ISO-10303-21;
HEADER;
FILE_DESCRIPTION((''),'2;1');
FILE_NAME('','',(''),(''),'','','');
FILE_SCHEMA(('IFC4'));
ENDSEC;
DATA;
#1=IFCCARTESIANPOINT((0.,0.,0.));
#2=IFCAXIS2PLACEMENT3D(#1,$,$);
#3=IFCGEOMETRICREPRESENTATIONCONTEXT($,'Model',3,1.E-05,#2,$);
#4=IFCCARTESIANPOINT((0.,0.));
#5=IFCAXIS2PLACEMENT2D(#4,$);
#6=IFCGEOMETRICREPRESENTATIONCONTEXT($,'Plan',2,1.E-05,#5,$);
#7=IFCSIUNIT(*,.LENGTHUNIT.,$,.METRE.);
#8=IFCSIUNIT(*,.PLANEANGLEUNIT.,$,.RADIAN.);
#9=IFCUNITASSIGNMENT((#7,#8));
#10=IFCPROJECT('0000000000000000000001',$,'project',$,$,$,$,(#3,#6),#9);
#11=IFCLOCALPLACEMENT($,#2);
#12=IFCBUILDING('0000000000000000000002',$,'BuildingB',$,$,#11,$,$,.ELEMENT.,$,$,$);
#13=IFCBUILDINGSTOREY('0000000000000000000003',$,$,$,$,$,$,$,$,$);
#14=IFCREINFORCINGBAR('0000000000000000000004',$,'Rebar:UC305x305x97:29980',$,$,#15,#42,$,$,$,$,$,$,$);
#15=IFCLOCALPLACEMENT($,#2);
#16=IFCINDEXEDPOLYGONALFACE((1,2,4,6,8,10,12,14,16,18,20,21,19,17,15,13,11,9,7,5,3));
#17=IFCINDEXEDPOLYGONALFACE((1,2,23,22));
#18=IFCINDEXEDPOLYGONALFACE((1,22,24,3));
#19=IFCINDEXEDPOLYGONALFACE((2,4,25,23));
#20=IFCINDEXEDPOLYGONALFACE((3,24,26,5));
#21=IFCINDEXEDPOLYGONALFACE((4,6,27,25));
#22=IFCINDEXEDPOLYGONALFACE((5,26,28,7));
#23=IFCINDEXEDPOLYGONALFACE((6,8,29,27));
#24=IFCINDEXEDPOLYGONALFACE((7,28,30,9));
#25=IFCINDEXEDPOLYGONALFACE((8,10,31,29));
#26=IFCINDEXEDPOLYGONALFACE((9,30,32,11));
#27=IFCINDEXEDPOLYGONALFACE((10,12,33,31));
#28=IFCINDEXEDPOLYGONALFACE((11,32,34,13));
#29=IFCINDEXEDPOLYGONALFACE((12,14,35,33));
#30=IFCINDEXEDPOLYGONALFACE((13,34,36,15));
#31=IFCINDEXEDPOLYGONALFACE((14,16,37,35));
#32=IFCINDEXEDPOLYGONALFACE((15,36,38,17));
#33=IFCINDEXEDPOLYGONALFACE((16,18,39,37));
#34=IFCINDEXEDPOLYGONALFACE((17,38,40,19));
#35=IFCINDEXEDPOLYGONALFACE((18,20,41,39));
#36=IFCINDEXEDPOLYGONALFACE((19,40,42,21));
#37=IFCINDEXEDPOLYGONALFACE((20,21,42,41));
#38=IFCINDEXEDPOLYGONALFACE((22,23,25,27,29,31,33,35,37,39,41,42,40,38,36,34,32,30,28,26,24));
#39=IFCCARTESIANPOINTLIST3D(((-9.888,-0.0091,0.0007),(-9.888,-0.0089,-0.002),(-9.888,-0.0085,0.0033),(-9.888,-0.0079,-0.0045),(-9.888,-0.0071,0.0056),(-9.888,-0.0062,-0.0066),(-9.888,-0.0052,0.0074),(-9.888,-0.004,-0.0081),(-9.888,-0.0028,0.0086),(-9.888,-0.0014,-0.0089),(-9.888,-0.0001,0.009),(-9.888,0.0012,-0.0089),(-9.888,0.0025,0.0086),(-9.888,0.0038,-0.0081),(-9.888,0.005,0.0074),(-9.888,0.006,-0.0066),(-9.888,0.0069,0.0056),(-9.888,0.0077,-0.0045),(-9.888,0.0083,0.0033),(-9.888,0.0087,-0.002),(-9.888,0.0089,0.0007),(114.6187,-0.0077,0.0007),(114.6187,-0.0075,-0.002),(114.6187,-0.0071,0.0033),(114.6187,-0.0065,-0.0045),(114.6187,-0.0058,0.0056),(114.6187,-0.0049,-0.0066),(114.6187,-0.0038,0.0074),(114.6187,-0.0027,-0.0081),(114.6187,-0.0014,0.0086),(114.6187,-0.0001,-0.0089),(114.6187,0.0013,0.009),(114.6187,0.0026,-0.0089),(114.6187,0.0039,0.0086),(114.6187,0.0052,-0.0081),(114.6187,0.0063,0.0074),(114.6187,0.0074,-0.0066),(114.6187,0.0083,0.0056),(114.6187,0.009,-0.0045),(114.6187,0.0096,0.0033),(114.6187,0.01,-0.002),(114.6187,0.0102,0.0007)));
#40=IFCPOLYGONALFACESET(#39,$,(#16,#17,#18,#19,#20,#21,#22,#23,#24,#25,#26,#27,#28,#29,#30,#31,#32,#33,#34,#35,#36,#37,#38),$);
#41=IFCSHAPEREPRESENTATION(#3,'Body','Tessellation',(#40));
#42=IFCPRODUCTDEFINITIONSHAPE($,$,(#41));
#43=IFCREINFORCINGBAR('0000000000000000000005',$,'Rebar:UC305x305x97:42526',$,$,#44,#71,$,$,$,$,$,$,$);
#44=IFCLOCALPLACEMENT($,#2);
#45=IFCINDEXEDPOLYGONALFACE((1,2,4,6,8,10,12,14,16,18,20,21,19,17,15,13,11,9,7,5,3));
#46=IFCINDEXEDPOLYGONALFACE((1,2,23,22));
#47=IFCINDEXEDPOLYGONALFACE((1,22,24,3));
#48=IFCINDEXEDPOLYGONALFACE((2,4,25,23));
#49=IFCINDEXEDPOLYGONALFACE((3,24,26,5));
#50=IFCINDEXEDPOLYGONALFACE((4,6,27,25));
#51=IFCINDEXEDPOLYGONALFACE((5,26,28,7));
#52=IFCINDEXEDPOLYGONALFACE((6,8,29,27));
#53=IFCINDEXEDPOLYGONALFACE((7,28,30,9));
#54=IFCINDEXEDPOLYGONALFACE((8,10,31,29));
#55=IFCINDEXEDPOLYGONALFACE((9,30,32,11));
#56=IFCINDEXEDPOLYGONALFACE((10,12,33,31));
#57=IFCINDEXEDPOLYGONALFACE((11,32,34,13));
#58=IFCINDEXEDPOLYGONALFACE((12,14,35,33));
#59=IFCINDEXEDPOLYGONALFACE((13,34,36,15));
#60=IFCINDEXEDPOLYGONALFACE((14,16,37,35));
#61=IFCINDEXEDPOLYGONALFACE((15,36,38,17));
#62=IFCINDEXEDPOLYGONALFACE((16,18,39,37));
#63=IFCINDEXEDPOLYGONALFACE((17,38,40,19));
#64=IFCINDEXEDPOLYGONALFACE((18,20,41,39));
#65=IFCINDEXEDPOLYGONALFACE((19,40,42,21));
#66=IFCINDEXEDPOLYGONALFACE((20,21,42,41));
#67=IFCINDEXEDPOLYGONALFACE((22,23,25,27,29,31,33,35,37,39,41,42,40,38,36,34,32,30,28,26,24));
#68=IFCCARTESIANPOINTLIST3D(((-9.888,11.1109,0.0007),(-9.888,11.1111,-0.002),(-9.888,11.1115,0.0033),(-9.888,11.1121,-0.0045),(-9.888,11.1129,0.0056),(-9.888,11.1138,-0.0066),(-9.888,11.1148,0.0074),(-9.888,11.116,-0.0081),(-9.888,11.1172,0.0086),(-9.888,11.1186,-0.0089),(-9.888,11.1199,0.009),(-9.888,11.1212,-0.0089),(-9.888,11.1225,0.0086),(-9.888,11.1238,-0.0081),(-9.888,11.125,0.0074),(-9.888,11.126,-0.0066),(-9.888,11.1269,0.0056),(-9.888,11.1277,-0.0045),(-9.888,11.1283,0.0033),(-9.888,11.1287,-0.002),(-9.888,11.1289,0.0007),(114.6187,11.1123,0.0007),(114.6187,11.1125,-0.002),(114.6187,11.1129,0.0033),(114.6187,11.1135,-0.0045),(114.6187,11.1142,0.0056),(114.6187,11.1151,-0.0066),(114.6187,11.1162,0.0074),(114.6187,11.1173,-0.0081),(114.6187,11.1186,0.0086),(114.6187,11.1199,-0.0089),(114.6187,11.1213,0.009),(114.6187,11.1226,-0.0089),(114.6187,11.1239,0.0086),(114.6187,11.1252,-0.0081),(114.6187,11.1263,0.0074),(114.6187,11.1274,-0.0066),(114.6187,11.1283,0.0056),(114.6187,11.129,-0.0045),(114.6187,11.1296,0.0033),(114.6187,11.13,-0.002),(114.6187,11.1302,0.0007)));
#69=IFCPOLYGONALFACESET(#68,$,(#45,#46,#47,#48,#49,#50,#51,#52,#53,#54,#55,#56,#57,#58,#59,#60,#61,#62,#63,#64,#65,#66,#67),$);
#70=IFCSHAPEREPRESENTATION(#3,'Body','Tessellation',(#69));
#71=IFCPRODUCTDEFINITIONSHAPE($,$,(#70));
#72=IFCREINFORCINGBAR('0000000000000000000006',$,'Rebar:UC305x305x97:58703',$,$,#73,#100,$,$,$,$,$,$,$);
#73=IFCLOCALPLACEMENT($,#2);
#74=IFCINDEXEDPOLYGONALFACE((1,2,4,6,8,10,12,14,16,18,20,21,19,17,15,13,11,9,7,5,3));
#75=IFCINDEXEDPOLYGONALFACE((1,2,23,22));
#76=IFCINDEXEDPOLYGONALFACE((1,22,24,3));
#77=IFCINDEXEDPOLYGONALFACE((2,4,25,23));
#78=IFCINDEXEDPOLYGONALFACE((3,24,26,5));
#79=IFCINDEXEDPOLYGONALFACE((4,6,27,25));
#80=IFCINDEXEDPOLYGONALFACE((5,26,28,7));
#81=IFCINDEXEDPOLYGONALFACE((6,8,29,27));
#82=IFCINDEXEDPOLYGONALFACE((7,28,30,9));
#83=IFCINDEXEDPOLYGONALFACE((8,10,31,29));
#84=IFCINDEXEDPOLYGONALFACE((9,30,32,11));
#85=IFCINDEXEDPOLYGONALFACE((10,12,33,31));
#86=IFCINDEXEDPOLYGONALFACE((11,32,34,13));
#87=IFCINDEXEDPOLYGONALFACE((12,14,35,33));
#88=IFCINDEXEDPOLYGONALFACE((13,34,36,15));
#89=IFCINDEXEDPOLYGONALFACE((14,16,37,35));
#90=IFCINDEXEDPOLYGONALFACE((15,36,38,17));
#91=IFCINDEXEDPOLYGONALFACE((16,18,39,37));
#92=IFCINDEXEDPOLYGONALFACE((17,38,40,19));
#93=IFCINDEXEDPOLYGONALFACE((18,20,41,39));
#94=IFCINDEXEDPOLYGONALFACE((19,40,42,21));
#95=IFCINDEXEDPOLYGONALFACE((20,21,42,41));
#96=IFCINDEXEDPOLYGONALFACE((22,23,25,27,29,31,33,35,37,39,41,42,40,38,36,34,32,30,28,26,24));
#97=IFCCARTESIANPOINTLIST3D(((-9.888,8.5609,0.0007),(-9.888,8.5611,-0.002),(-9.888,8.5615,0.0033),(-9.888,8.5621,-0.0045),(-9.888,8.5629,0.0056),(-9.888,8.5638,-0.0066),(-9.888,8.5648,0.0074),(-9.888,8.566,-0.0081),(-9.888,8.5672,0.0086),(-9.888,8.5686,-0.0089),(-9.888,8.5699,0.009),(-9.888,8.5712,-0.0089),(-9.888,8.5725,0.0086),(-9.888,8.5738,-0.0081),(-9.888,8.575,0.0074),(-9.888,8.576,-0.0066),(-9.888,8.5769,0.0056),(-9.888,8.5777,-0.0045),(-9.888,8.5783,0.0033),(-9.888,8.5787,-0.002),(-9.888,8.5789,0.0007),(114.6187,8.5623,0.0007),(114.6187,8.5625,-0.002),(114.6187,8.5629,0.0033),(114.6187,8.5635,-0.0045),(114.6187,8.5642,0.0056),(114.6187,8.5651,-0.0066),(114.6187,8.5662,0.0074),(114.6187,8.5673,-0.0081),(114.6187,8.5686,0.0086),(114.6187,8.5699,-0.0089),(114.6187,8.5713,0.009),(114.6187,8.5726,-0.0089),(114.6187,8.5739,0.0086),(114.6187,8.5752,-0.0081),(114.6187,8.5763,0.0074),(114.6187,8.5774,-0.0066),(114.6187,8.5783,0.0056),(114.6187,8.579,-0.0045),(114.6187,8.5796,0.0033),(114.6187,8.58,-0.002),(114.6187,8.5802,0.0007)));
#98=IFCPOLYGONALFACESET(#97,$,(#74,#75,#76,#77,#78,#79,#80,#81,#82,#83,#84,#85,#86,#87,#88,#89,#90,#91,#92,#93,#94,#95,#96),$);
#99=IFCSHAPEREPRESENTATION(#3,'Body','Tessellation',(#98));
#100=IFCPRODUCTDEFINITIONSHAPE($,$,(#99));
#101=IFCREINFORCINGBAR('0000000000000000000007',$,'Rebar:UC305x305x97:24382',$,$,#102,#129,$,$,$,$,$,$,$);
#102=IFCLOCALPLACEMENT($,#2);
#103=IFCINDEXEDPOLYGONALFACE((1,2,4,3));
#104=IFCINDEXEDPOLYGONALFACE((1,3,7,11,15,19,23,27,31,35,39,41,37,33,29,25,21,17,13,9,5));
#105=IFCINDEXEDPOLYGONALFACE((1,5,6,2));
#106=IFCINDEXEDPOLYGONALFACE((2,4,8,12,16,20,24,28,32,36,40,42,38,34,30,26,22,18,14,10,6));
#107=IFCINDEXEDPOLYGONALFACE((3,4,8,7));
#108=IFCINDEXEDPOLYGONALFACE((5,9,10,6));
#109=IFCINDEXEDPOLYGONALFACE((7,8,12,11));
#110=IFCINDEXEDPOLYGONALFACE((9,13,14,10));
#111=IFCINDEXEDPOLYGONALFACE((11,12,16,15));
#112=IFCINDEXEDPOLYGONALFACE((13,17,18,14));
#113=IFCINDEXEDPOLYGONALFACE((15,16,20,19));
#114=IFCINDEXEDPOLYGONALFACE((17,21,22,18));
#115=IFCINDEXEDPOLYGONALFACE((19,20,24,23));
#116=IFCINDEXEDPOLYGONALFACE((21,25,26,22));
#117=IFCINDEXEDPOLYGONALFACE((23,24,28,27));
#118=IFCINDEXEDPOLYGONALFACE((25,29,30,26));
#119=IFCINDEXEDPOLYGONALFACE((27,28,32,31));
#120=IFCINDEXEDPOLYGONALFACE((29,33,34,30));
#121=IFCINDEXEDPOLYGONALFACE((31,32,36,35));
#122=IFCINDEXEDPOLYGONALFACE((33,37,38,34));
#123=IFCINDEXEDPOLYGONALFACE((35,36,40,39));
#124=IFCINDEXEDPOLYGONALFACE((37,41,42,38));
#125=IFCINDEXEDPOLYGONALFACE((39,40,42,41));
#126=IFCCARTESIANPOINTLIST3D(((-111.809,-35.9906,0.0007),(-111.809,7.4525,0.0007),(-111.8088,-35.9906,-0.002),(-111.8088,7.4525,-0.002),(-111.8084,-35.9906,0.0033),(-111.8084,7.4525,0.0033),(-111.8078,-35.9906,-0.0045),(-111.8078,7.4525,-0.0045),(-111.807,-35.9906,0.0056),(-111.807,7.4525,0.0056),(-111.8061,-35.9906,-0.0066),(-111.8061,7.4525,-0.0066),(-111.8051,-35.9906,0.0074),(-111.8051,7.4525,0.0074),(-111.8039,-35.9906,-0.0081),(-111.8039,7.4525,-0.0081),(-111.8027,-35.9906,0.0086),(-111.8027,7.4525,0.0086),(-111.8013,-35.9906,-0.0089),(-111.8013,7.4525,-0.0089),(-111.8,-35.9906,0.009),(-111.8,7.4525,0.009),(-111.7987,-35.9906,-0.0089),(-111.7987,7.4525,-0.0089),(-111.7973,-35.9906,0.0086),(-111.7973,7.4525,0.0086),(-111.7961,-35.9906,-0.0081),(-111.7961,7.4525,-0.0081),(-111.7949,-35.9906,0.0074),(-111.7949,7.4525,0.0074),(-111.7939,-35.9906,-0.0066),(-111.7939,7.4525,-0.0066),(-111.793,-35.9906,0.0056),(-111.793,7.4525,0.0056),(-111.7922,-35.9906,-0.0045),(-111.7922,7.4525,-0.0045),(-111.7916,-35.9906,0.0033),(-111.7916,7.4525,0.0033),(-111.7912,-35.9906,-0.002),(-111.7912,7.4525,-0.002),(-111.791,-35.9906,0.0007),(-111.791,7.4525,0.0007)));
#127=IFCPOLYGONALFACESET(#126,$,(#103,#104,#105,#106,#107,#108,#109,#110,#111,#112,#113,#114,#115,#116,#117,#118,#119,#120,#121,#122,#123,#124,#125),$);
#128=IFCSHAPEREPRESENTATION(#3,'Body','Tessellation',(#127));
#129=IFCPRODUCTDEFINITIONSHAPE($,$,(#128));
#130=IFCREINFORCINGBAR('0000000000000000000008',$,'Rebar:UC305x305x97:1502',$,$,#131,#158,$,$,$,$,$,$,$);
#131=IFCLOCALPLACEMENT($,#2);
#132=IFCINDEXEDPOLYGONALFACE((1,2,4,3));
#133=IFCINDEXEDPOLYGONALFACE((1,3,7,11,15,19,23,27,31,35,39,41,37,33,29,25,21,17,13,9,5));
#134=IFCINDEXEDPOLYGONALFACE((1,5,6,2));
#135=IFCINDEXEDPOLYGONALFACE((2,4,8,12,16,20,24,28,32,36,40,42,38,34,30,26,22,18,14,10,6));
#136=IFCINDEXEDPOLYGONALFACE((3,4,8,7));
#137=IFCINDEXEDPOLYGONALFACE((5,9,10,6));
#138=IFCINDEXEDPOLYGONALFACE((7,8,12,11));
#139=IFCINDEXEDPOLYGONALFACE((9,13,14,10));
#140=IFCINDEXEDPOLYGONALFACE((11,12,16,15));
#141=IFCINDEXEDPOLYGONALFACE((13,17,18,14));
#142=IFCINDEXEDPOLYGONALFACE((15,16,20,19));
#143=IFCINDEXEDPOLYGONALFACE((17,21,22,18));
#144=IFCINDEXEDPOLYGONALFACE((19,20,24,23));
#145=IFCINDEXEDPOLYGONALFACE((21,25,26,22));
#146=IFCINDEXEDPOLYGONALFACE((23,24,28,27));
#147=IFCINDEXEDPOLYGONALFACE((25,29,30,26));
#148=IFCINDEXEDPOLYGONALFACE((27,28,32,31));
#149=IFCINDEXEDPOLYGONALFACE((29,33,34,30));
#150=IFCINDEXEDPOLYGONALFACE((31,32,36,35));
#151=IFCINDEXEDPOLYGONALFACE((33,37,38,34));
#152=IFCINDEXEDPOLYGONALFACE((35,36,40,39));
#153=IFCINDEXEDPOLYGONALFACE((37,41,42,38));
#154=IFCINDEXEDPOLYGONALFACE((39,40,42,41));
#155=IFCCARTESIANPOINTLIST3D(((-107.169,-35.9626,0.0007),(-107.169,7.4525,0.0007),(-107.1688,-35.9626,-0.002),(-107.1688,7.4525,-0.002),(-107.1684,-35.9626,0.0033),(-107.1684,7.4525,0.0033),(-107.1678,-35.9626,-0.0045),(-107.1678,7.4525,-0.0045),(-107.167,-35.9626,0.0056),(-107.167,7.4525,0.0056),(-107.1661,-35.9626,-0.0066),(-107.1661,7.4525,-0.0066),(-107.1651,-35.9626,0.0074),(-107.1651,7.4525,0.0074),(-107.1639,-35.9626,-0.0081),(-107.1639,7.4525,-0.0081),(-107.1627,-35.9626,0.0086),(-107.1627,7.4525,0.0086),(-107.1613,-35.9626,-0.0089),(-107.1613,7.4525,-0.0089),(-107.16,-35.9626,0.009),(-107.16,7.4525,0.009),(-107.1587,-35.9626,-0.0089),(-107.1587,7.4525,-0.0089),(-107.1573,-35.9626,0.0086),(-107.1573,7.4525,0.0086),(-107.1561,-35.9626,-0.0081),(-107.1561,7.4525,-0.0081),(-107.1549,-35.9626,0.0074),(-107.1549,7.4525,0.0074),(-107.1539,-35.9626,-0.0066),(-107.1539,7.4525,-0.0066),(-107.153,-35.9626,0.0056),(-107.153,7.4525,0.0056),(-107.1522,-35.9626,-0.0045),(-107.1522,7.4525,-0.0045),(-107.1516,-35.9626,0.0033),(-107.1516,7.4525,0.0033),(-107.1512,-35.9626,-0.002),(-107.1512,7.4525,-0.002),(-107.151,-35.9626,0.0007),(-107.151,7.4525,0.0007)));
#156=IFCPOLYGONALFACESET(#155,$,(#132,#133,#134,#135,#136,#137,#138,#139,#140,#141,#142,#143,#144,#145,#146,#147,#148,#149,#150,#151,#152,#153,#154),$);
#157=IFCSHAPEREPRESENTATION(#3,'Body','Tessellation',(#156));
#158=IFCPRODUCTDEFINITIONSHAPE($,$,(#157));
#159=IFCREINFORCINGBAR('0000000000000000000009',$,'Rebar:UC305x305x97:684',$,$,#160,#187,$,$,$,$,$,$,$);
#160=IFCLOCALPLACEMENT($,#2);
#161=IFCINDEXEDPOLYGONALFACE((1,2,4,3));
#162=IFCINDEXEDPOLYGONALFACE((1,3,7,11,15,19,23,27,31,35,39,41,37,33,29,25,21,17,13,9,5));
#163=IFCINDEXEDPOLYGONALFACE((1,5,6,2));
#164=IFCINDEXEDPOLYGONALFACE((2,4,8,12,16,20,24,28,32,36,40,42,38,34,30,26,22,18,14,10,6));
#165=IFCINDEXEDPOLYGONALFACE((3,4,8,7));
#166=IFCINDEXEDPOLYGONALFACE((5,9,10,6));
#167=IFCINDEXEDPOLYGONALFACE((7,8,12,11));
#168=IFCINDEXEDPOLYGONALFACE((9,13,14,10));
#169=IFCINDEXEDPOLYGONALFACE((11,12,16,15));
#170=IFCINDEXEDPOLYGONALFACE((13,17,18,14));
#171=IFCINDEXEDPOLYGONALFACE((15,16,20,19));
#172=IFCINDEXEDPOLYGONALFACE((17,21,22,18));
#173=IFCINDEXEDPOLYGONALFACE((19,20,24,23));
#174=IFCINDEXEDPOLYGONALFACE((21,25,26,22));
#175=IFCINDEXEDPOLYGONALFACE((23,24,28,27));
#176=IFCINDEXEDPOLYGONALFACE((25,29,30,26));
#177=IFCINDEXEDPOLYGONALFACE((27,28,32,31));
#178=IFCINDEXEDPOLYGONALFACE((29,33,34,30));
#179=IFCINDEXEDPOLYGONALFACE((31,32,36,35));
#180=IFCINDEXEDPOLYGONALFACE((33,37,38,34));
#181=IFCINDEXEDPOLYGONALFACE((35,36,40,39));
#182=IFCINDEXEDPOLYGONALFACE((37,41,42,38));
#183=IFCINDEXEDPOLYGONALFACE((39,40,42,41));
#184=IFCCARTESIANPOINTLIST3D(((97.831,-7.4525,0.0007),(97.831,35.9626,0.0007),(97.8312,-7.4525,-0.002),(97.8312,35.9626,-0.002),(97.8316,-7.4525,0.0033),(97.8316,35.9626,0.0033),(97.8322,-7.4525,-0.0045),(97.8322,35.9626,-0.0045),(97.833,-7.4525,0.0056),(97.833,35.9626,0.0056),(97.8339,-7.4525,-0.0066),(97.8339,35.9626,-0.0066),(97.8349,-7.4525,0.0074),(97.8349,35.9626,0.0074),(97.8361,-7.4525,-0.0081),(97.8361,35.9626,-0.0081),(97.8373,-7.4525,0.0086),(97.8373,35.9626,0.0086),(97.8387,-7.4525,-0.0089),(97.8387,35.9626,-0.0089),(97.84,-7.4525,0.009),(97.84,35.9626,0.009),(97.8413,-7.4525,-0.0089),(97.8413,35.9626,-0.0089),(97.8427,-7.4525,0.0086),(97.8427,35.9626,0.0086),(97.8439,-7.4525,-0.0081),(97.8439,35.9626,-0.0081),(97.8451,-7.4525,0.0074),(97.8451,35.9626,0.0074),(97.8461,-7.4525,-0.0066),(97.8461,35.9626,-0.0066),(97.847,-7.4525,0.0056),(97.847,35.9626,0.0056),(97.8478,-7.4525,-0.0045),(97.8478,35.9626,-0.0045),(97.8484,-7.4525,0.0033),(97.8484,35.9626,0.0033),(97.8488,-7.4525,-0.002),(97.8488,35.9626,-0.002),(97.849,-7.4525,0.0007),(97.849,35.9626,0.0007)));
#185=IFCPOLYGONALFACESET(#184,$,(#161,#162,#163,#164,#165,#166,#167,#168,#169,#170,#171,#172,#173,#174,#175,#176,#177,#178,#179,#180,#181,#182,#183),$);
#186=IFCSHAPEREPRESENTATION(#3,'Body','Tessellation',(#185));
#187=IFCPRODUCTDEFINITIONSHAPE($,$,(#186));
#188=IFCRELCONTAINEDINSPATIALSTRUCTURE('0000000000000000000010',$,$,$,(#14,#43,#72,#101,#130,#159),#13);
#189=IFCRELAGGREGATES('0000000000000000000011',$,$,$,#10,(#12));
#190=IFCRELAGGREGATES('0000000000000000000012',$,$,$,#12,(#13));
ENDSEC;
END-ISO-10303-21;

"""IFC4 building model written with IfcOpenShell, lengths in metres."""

from ifc_helpers import new_model, entity, si_unit, origin, origin_2d, place, context, project, spatial, element, save


model = new_model("IFC4")

# Units and contexts
model_context = context("Model", 3, precision=1e-05, world=origin())
plan_context = context("Plan", 2, precision=1e-05, world=origin_2d())
ifc_project = project(units=[si_unit("LENGTHUNIT", "METRE"), si_unit("PLANEANGLEUNIT", "RADIAN")], contexts=[model_context, plan_context])

# Building, storey
building_placement = place(None, origin())
building = spatial("IfcBuilding", under=ifc_project, at=building_placement, Name="BuildingB", CompositionType="ELEMENT")
storey = spatial("IfcBuildingStorey", under=building)

# Reinforcing bars
element("IfcReinforcingBar", 1, inside=storey, Name="Rebar:UC305x305x97:29980", context=model_context, shape_type="SweptSolid", body=[
    entity("IfcSurfaceCurveSweptAreaSolid", entity("IfcCircleProfileDef", "AREA", None, None, 0.009), None, entity("IfcPolyline", [entity("IfcCartesianPoint", [-9.888, -0.0001, 0.0]), entity("IfcCartesianPoint", [114.6187, 0.0013, 0.0])]), None, None, entity("IfcPlane", entity("IfcAxis2Placement3D", entity("IfcCartesianPoint", [-9.888, -0.0001, 0.0]), entity("IfcDirection", [0.0, 0.0, 1.0]), entity("IfcDirection", [1.0, 0.0, 0.0])))),
])
element("IfcReinforcingBar", 2, inside=storey, Name="Rebar:UC305x305x97:42526", context=model_context, shape_type="SweptSolid", body=[
    entity("IfcSurfaceCurveSweptAreaSolid", entity("IfcCircleProfileDef", "AREA", None, None, 0.009), None, entity("IfcPolyline", [entity("IfcCartesianPoint", [-9.888, 11.1199, 0.0]), entity("IfcCartesianPoint", [114.6187, 11.1213, 0.0])]), None, None, entity("IfcPlane", entity("IfcAxis2Placement3D", entity("IfcCartesianPoint", [-9.888, 11.1199, 0.0]), entity("IfcDirection", [0.0, 0.0, 1.0]), entity("IfcDirection", [1.0, 0.0, 0.0])))),
])
element("IfcReinforcingBar", 3, inside=storey, Name="Rebar:UC305x305x97:58703", context=model_context, shape_type="SweptSolid", body=[
    entity("IfcSurfaceCurveSweptAreaSolid", entity("IfcCircleProfileDef", "AREA", None, None, 0.009), None, entity("IfcPolyline", [entity("IfcCartesianPoint", [-9.888, 8.5699, 0.0]), entity("IfcCartesianPoint", [114.6187, 8.5713, 0.0])]), None, None, entity("IfcPlane", entity("IfcAxis2Placement3D", entity("IfcCartesianPoint", [-9.888, 8.5699, 0.0]), entity("IfcDirection", [0.0, 0.0, 1.0]), entity("IfcDirection", [1.0, 0.0, 0.0])))),
])
element("IfcReinforcingBar", 4, inside=storey, Name="Rebar:UC305x305x97:24382", context=model_context, shape_type="SweptSolid", body=[
    entity("IfcSurfaceCurveSweptAreaSolid", entity("IfcCircleProfileDef", "AREA", None, None, 0.009), None, entity("IfcPolyline", [entity("IfcCartesianPoint", [111.8, 35.9906, 0.0]), entity("IfcCartesianPoint", [111.8, -7.4525, 0.0])]), None, None, entity("IfcPlane", entity("IfcAxis2Placement3D", entity("IfcCartesianPoint", [111.8, 35.9906, 0.0]), entity("IfcDirection", [0.0, 0.0, 1.0]), entity("IfcDirection", [1.0, 0.0, 0.0])))),
])
element("IfcReinforcingBar", 5, inside=storey, Name="Rebar:UC305x305x97:1502", context=model_context, shape_type="SweptSolid", body=[
    entity("IfcSurfaceCurveSweptAreaSolid", entity("IfcCircleProfileDef", "AREA", None, None, 0.009), None, entity("IfcPolyline", [entity("IfcCartesianPoint", [107.16, 35.9626, 0.0]), entity("IfcCartesianPoint", [107.16, -7.4525, 0.0])]), None, None, entity("IfcPlane", entity("IfcAxis2Placement3D", entity("IfcCartesianPoint", [107.16, 35.9626, 0.0]), entity("IfcDirection", [0.0, 0.0, 1.0]), entity("IfcDirection", [1.0, 0.0, 0.0])))),
])
element("IfcReinforcingBar", 6, inside=storey, Name="Rebar:UC305x305x97:684", context=model_context, shape_type="SweptSolid", body=[
    entity("IfcSurfaceCurveSweptAreaSolid", entity("IfcCircleProfileDef", "AREA", None, None, 0.009), None, entity("IfcPolyline", [entity("IfcCartesianPoint", [97.84, 35.9626, 0.0]), entity("IfcCartesianPoint", [97.84, -7.4525, 0.0])]), None, None, entity("IfcPlane", entity("IfcAxis2Placement3D", entity("IfcCartesianPoint", [97.84, 35.9626, 0.0]), entity("IfcDirection", [0.0, 0.0, 1.0]), entity("IfcDirection", [1.0, 0.0, 0.0])))),
])

save(model, "model.ifc")
